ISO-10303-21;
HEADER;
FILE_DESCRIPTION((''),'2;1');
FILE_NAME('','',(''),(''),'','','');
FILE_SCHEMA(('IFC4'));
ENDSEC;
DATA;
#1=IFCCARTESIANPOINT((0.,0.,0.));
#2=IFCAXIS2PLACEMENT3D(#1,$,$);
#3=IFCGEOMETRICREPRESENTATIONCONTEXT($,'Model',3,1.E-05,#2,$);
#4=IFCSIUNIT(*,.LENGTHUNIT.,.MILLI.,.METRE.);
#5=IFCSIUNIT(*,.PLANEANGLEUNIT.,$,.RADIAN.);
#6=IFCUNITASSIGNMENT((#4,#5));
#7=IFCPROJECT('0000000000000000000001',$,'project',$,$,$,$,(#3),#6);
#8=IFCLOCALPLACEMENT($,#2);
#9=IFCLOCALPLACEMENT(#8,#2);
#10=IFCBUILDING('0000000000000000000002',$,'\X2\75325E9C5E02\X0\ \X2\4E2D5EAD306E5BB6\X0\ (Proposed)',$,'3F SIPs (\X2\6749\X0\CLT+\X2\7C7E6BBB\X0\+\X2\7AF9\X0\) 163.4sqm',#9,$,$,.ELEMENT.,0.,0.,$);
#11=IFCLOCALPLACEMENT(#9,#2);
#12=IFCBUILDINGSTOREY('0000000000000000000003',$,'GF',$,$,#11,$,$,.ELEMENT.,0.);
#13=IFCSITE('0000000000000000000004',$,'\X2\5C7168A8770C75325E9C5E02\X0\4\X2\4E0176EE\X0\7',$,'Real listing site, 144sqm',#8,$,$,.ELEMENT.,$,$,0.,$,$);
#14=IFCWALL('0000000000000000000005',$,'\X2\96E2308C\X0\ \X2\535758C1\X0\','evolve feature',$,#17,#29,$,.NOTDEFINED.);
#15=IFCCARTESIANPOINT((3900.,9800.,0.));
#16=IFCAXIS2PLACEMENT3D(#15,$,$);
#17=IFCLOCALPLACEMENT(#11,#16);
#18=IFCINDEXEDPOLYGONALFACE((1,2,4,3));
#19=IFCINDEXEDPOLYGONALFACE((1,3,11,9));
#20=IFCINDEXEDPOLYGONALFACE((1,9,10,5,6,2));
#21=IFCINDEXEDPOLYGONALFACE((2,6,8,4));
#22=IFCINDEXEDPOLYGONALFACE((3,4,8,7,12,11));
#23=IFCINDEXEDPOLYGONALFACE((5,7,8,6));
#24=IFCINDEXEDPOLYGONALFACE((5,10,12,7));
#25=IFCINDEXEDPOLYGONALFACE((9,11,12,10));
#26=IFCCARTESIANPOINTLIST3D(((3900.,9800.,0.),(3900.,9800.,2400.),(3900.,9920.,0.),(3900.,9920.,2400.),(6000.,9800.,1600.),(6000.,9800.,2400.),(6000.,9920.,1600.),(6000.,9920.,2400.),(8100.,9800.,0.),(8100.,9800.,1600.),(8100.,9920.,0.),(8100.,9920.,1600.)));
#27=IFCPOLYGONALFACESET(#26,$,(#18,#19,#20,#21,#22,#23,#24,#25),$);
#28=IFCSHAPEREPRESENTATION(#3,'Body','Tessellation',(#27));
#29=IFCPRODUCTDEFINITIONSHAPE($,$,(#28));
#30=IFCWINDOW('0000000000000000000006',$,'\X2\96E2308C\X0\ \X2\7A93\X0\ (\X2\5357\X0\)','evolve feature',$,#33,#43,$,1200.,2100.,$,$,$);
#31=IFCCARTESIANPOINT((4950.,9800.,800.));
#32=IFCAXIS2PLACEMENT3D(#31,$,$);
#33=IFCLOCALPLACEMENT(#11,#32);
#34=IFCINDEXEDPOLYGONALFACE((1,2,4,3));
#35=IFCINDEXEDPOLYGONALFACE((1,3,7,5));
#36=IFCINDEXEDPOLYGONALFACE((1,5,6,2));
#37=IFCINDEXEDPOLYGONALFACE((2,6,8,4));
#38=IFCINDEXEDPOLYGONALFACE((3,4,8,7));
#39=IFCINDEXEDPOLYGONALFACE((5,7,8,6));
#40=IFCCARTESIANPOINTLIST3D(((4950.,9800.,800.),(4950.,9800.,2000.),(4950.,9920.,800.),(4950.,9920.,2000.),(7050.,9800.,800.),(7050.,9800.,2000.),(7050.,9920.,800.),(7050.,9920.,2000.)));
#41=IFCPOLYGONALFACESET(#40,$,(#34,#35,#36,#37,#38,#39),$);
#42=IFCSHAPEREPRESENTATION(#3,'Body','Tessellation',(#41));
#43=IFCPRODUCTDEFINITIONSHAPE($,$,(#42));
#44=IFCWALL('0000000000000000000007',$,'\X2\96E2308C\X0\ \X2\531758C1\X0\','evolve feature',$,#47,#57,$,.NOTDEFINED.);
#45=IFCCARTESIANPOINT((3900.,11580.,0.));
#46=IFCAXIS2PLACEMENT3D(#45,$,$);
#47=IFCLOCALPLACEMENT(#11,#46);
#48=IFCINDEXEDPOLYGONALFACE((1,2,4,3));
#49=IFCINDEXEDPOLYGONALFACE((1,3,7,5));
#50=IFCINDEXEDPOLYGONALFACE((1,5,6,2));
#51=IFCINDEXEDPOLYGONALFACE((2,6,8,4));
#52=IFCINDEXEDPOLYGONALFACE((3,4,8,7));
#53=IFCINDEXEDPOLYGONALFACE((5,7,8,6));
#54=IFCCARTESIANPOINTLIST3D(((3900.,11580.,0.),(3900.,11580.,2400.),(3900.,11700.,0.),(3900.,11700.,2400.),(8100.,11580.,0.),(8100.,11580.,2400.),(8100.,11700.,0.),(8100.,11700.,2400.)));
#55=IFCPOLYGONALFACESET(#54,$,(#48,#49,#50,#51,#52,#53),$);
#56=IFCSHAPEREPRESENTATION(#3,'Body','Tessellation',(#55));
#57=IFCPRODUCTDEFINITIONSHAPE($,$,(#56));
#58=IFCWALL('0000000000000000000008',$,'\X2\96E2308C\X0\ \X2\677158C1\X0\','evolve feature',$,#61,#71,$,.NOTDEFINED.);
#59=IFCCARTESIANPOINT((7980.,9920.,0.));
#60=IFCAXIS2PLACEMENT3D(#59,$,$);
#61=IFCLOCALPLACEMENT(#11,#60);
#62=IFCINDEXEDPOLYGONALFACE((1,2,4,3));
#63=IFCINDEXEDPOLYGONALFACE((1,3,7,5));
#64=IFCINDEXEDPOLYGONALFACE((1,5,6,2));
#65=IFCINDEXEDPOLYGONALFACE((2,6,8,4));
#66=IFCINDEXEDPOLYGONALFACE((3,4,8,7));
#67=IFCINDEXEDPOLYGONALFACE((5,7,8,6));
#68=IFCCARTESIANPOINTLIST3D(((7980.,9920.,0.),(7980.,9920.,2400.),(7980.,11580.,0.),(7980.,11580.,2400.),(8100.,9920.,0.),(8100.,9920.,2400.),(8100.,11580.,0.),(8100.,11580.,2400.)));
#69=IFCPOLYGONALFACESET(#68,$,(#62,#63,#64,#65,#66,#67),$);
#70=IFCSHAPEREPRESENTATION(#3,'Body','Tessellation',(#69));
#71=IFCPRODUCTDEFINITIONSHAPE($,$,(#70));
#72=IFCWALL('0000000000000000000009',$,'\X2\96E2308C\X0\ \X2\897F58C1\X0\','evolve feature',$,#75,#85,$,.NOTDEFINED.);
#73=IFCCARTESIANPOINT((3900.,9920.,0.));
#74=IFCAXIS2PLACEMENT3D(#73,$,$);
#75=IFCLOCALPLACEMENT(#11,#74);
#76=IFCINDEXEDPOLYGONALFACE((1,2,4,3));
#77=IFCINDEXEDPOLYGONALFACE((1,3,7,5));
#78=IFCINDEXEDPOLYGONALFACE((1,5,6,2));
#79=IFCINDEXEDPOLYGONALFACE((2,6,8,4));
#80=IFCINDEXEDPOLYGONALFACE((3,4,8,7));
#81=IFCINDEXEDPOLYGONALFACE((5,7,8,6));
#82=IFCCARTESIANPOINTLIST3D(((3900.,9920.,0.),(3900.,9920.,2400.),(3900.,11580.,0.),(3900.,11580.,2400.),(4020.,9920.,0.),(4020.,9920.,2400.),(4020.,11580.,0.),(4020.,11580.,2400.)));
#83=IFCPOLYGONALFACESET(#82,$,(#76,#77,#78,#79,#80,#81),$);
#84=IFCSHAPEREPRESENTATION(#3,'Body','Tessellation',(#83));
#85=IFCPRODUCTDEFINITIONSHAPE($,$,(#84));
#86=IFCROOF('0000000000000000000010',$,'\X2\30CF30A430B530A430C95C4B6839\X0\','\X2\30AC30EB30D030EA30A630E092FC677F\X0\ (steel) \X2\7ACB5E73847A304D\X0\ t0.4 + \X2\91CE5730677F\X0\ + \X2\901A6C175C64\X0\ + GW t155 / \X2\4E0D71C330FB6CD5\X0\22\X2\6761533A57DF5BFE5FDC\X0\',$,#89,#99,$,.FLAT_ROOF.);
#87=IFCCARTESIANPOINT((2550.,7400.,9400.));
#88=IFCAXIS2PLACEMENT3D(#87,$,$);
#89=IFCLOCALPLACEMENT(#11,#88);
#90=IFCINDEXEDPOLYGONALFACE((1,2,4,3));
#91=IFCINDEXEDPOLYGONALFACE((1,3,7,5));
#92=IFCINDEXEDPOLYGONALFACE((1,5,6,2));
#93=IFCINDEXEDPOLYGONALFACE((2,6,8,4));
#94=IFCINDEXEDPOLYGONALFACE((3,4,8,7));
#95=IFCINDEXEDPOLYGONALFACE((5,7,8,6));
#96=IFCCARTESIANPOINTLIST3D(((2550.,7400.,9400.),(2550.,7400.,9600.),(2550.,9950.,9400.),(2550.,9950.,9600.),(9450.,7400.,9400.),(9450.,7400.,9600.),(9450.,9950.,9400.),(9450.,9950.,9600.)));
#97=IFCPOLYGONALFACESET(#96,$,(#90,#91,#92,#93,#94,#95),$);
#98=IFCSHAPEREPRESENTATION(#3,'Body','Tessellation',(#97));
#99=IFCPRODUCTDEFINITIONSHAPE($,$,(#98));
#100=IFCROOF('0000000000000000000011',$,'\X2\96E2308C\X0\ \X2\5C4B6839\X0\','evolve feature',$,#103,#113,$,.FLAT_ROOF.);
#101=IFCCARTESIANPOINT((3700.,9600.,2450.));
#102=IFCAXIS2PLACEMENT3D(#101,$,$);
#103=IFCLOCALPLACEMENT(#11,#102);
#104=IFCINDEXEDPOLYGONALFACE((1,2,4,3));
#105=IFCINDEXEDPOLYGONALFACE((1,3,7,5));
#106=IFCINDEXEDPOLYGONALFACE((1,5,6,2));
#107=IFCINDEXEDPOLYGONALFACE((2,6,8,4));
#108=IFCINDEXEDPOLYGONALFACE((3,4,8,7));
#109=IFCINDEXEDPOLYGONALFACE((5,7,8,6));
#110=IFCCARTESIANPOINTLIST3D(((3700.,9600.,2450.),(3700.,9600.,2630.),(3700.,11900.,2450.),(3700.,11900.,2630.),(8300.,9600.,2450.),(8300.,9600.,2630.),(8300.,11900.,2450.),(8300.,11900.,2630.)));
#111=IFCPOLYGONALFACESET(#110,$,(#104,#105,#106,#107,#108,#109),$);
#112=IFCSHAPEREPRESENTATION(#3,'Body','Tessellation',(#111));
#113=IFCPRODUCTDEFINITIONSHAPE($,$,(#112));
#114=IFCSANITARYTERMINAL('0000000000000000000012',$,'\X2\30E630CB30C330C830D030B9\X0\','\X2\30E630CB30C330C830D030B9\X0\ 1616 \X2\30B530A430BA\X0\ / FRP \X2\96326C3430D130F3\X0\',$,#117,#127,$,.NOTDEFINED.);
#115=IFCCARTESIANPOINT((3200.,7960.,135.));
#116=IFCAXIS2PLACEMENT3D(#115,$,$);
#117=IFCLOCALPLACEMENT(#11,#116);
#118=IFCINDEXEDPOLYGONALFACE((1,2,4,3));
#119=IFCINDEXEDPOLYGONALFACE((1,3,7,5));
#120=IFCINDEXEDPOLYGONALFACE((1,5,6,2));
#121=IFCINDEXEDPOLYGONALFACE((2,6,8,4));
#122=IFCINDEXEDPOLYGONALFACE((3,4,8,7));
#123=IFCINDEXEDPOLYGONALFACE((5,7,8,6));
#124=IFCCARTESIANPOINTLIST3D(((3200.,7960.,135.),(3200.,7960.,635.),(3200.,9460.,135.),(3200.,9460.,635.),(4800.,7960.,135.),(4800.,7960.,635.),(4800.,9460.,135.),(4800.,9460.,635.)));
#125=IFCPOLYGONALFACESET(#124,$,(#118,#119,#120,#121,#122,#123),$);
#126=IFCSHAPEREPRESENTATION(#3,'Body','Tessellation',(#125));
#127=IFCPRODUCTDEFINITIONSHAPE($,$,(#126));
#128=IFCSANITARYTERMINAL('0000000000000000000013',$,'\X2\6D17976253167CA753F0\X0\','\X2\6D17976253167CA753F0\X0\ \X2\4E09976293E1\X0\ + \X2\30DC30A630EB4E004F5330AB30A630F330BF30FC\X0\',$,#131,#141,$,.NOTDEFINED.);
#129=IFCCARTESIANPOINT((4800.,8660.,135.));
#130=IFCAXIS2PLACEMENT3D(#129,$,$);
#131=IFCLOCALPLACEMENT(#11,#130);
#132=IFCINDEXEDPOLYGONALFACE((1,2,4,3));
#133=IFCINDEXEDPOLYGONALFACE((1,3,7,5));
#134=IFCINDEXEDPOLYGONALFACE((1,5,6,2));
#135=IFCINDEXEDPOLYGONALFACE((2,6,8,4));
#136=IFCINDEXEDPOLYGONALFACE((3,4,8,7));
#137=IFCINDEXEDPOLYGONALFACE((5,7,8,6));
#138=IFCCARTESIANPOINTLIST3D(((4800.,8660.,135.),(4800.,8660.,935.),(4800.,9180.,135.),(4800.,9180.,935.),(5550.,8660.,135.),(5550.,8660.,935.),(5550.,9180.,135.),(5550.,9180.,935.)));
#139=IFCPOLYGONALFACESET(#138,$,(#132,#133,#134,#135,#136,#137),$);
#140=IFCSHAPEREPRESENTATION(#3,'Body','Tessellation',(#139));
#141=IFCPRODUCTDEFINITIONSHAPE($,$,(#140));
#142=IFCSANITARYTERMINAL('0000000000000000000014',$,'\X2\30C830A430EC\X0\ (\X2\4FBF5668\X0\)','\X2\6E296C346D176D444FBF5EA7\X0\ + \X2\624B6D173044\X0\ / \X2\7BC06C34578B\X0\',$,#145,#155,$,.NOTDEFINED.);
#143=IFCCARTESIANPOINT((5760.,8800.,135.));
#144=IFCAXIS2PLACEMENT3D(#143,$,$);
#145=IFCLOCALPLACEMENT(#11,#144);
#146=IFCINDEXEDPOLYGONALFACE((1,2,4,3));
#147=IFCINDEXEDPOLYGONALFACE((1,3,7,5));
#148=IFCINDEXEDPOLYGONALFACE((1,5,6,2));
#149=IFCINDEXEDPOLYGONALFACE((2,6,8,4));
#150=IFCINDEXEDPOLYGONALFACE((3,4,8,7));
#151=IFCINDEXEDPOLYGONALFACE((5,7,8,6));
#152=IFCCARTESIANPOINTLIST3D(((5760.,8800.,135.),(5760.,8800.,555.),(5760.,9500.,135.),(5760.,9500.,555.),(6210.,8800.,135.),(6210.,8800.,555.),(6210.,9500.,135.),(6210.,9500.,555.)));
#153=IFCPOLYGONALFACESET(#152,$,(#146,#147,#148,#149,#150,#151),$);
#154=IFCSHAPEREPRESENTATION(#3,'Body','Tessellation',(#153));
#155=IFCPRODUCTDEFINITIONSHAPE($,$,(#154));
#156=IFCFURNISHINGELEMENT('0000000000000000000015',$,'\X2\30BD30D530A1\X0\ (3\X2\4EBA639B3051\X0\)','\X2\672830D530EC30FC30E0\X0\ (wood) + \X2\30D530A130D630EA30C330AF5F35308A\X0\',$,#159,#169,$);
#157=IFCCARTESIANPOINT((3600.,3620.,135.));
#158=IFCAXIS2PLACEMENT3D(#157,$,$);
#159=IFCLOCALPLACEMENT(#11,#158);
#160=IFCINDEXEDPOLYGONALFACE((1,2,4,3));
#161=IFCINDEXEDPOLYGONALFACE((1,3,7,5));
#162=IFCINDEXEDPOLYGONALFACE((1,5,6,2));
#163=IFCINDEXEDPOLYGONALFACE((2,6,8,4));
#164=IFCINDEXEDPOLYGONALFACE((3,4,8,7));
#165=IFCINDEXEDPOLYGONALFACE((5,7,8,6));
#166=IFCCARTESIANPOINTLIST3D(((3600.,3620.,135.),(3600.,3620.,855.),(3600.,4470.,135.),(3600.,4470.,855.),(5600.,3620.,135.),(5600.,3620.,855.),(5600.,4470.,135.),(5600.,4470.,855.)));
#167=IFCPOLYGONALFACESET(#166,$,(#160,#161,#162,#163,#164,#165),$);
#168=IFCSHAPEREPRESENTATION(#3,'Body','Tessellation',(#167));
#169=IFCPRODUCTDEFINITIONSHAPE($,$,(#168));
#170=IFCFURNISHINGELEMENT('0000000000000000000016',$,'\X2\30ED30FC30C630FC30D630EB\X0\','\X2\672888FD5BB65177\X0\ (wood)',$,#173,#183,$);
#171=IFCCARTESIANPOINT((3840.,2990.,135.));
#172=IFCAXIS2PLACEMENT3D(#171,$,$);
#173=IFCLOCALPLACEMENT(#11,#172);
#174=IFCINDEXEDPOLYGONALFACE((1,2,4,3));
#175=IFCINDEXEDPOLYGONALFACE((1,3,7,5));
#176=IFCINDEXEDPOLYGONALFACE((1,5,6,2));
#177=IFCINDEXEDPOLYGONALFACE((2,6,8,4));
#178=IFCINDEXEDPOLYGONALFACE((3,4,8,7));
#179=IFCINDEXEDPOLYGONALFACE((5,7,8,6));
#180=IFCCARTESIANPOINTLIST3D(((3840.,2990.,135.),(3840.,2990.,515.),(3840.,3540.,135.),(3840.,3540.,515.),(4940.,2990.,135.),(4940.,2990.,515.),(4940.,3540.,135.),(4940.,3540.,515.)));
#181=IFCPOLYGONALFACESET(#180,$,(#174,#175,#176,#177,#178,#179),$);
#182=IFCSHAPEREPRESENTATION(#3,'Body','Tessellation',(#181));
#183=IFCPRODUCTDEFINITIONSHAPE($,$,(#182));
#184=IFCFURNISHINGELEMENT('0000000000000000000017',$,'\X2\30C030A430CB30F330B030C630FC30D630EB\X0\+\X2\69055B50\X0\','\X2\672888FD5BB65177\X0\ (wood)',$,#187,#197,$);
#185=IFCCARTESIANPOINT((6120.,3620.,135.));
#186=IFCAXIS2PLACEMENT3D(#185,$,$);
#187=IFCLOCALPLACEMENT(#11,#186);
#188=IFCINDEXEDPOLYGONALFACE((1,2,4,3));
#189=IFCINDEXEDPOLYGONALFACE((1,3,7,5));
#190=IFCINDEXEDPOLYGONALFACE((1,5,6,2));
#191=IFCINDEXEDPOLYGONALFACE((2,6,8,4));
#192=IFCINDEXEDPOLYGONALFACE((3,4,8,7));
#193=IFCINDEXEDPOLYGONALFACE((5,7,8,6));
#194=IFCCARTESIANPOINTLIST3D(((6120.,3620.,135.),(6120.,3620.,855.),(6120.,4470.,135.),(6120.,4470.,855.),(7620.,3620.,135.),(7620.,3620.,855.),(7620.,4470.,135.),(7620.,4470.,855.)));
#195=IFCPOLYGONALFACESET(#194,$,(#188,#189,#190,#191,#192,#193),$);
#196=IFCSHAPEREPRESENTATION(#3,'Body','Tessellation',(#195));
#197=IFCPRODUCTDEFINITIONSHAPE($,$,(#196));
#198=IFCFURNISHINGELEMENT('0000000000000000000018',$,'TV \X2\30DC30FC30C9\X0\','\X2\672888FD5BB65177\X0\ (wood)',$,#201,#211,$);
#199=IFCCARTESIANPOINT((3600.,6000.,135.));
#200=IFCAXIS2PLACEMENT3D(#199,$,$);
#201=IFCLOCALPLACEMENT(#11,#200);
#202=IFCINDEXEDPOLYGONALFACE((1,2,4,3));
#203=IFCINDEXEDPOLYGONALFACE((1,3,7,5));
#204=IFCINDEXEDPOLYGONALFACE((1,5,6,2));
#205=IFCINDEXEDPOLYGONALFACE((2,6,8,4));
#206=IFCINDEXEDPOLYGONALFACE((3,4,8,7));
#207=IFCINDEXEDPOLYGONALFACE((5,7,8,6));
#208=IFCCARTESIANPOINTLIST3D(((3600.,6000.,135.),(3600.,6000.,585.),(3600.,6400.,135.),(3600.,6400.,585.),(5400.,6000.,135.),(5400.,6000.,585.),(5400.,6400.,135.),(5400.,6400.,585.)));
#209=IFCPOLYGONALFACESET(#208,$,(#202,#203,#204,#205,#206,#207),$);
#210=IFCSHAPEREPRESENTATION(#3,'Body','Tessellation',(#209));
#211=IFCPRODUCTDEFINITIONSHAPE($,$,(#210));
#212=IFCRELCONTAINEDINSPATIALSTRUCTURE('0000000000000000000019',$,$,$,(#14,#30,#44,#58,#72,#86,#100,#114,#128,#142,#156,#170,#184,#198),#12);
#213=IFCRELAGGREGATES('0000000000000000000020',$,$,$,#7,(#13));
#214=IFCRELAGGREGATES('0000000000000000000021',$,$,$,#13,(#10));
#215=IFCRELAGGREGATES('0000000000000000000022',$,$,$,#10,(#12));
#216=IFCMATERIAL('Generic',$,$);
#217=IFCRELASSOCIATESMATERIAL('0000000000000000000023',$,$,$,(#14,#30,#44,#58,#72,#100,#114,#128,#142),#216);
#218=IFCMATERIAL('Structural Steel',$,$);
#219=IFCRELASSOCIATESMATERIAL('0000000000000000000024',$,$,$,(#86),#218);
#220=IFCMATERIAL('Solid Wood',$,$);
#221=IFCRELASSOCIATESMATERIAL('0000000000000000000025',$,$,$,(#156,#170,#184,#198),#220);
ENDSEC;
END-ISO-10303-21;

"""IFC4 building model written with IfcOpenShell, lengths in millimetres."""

from ifc_helpers import new_model, si_unit, frame, frame_2d, origin, place, context, project, spatial, rectangle, extrude, material, element, fill, save


model = new_model("IFC4")

# Units and contexts
model_context = context("Model", 3, precision=1e-05, world=origin())
ifc_project = project(units=[si_unit("LENGTHUNIT", "METRE", prefix="MILLI"), si_unit("PLANEANGLEUNIT", "RADIAN")], contexts=[model_context])

# Site, building, storey
site_placement = place(None, origin())
site = spatial("IfcSite", under=ifc_project, at=site_placement, Name="山梨県甲府市4丁目7", ObjectType="Real listing site, 144sqm", CompositionType="ELEMENT", RefElevation=0.0)
building_placement = place(site_placement, origin())
building = spatial("IfcBuilding", under=site, at=building_placement, Name="甲府市 中庭の家 (Proposed)", ObjectType="3F SIPs (杉CLT+籾殻+竹) 163.4sqm", CompositionType="ELEMENT", ElevationOfRefHeight=0.0, ElevationOfTerrain=0.0)
storey_placement = place(building_placement, origin())
storey = spatial("IfcBuildingStorey", under=building, at=storey_placement, Name="GF", CompositionType="ELEMENT", Elevation=0.0)

# Shared definitions
ifc_material_1 = material(Name="Generic")

# Shared definitions
ifc_material_2 = material(Name="Solid Wood")

# Wall, opening, window
wall_1_placement = place(storey_placement, frame((3900.0, 9800.0, 0.0)))
wall_1 = element("IfcWall", 1, at=wall_1_placement, inside=storey, material=ifc_material_1, Name="離れ 南壁", Description="evolve feature", PredefinedType="NOTDEFINED", context=model_context, shape_type="SweptSolid", body=[
    extrude(rectangle(XDim=4200.0, YDim=120.0, at=frame_2d((2100.0, 60.0))), frame((3900.0, 9800.0, 0.0)), (0.0, 0.0, 1.0), 2400.0),
])
opening_1_placement = place(storey_placement, frame((4950.0, 9800.0, 800.0)))
opening_1 = element("IfcOpeningElement", 2, at=opening_1_placement, cuts=wall_1, PredefinedType="NOTDEFINED", context=model_context, shape_type="SweptSolid", body=[
    extrude(rectangle(XDim=2100.0, YDim=120.0, at=frame_2d((1050.0, 60.0))), frame((4950.0, 9800.0, 800.0)), (0.0, 0.0, 1.0), 1200.0),
])
window_1_placement = place(storey_placement, frame((4950.0, 9800.0, 800.0)))
window_1 = element("IfcWindow", 3, at=window_1_placement, inside=storey, material=ifc_material_1, Name="離れ 窓 (南)", Description="evolve feature", OverallHeight=1200.0, OverallWidth=2100.0, context=model_context, shape_type="SweptSolid", body=[
    extrude(rectangle(XDim=2100.0, YDim=120.0, at=frame_2d((1050.0, 60.0))), frame((4950.0, 9800.0, 800.0)), (0.0, 0.0, 1.0), 1200.0),
])
fill(opening_1, window_1)

# Walls
wall_2_placement = place(storey_placement, frame((3900.0, 11580.0, 0.0)))
element("IfcWall", 4, at=wall_2_placement, inside=storey, material=ifc_material_1, Name="離れ 北壁", Description="evolve feature", PredefinedType="NOTDEFINED", context=model_context, shape_type="SweptSolid", body=[
    extrude(rectangle(XDim=4200.0, YDim=120.0, at=frame_2d((2100.0, 60.0))), frame((3900.0, 11580.0, 0.0)), (0.0, 0.0, 1.0), 2400.0),
])
wall_3_placement = place(storey_placement, frame((7980.0, 9920.0, 0.0)))
element("IfcWall", 5, at=wall_3_placement, inside=storey, material=ifc_material_1, Name="離れ 東壁", Description="evolve feature", PredefinedType="NOTDEFINED", context=model_context, shape_type="SweptSolid", body=[
    extrude(rectangle(XDim=120.0, YDim=1660.0, at=frame_2d((60.0, 830.0))), frame((7980.0, 9920.0, 0.0)), (0.0, 0.0, 1.0), 2400.0),
])
wall_4_placement = place(storey_placement, frame((3900.0, 9920.0, 0.0)))
element("IfcWall", 6, at=wall_4_placement, inside=storey, material=ifc_material_1, Name="離れ 西壁", Description="evolve feature", PredefinedType="NOTDEFINED", context=model_context, shape_type="SweptSolid", body=[
    extrude(rectangle(XDim=120.0, YDim=1660.0, at=frame_2d((60.0, 830.0))), frame((3900.0, 9920.0, 0.0)), (0.0, 0.0, 1.0), 2400.0),
])

# Roofs
ifc_material_3 = material(Name="Structural Steel")
roof_1_placement = place(storey_placement, frame((2550.0, 7400.0, 9400.0)))
element("IfcRoof", 7, at=roof_1_placement, inside=storey, material=ifc_material_3, Name="ハイサイド屋根", Description="ガルバリウム鋼板 (steel) 立平葺き t0.4 + 野地板 + 通気層 + GW t155 / 不燃・法22条区域対応", PredefinedType="FLAT_ROOF", context=model_context, shape_type="SweptSolid", body=[
    extrude(rectangle(XDim=6900.0, YDim=2550.0, at=frame_2d((3450.0, 1275.0))), frame((2550.0, 7400.0, 9400.0)), (0.0, 0.0, 1.0), 200.0),
])
roof_2_placement = place(storey_placement, frame((3700.0, 9600.0, 2450.0)))
element("IfcRoof", 8, at=roof_2_placement, inside=storey, material=ifc_material_1, Name="離れ 屋根", Description="evolve feature", PredefinedType="FLAT_ROOF", context=model_context, shape_type="SweptSolid", body=[
    extrude(rectangle(XDim=4600.0, YDim=2300.0, at=frame_2d((2300.0, 1150.0))), frame((3700.0, 9600.0, 2450.0)), (0.0, 0.0, 1.0), 180.0),
])

# Sanitary terminals
sanitary_terminal_1_placement = place(storey_placement, frame((3200.0, 7960.0, 135.0)))
element("IfcSanitaryTerminal", 9, at=sanitary_terminal_1_placement, inside=storey, material=ifc_material_1, Name="ユニットバス", Description="ユニットバス 1616 サイズ / FRP 防水パン", PredefinedType="NOTDEFINED", context=model_context, shape_type="SweptSolid", body=[
    extrude(rectangle(XDim=1600.0, YDim=1500.0, at=frame_2d((800.0, 750.0))), frame((3200.0, 7960.0, 135.0)), (0.0, 0.0, 1.0), 500.0),
])
sanitary_terminal_2_placement = place(storey_placement, frame((4800.0, 8660.0, 135.0)))
element("IfcSanitaryTerminal", 10, at=sanitary_terminal_2_placement, inside=storey, material=ifc_material_1, Name="洗面化粧台", Description="洗面化粧台 三面鏡 + ボウル一体カウンター", PredefinedType="NOTDEFINED", context=model_context, shape_type="SweptSolid", body=[
    extrude(rectangle(XDim=750.0, YDim=520.0, at=frame_2d((375.0, 260.0))), frame((4800.0, 8660.0, 135.0)), (0.0, 0.0, 1.0), 800.0),
])
sanitary_terminal_3_placement = place(storey_placement, frame((5760.0, 8800.0, 135.0)))
element("IfcSanitaryTerminal", 11, at=sanitary_terminal_3_placement, inside=storey, material=ifc_material_1, Name="トイレ (便器)", Description="温水洗浄便座 + 手洗い / 節水型", PredefinedType="NOTDEFINED", context=model_context, shape_type="SweptSolid", body=[
    extrude(rectangle(XDim=450.0, YDim=700.0, at=frame_2d((225.0, 350.0))), frame((5760.0, 8800.0, 135.0)), (0.0, 0.0, 1.0), 420.0),
])

# Furnishing elements
furnishing_1_placement = place(storey_placement, frame((3600.0, 3620.0, 135.0)))
element("IfcFurnishingElement", 12, at=furnishing_1_placement, inside=storey, material=ifc_material_2, Name="ソファ (3人掛け)", Description="木フレーム (wood) + ファブリック張り", context=model_context, shape_type="SweptSolid", body=[
    extrude(rectangle(XDim=2000.0, YDim=850.0, at=frame_2d((1000.0, 425.0))), frame((3600.0, 3620.0, 135.0)), (0.0, 0.0, 1.0), 720.0),
])
furnishing_2_placement = place(storey_placement, frame((3840.0, 2990.0, 135.0)))
element("IfcFurnishingElement", 13, at=furnishing_2_placement, inside=storey, material=ifc_material_2, Name="ローテーブル", Description="木製家具 (wood)", context=model_context, shape_type="SweptSolid", body=[
    extrude(rectangle(XDim=1100.0, YDim=550.0, at=frame_2d((550.0, 275.0))), frame((3840.0, 2990.0, 135.0)), (0.0, 0.0, 1.0), 380.0),
])
furnishing_3_placement = place(storey_placement, frame((6120.0, 3620.0, 135.0)))
element("IfcFurnishingElement", 14, at=furnishing_3_placement, inside=storey, material=ifc_material_2, Name="ダイニングテーブル+椅子", Description="木製家具 (wood)", context=model_context, shape_type="SweptSolid", body=[
    extrude(rectangle(XDim=1500.0, YDim=850.0, at=frame_2d((750.0, 425.0))), frame((6120.0, 3620.0, 135.0)), (0.0, 0.0, 1.0), 720.0),
])
furnishing_4_placement = place(storey_placement, frame((3600.0, 6000.0, 135.0)))
element("IfcFurnishingElement", 15, at=furnishing_4_placement, inside=storey, material=ifc_material_2, Name="TV ボード", Description="木製家具 (wood)", context=model_context, shape_type="SweptSolid", body=[
    extrude(rectangle(XDim=1800.0, YDim=400.0, at=frame_2d((900.0, 200.0))), frame((3600.0, 6000.0, 135.0)), (0.0, 0.0, 1.0), 450.0),
])

save(model, "model.ifc")
